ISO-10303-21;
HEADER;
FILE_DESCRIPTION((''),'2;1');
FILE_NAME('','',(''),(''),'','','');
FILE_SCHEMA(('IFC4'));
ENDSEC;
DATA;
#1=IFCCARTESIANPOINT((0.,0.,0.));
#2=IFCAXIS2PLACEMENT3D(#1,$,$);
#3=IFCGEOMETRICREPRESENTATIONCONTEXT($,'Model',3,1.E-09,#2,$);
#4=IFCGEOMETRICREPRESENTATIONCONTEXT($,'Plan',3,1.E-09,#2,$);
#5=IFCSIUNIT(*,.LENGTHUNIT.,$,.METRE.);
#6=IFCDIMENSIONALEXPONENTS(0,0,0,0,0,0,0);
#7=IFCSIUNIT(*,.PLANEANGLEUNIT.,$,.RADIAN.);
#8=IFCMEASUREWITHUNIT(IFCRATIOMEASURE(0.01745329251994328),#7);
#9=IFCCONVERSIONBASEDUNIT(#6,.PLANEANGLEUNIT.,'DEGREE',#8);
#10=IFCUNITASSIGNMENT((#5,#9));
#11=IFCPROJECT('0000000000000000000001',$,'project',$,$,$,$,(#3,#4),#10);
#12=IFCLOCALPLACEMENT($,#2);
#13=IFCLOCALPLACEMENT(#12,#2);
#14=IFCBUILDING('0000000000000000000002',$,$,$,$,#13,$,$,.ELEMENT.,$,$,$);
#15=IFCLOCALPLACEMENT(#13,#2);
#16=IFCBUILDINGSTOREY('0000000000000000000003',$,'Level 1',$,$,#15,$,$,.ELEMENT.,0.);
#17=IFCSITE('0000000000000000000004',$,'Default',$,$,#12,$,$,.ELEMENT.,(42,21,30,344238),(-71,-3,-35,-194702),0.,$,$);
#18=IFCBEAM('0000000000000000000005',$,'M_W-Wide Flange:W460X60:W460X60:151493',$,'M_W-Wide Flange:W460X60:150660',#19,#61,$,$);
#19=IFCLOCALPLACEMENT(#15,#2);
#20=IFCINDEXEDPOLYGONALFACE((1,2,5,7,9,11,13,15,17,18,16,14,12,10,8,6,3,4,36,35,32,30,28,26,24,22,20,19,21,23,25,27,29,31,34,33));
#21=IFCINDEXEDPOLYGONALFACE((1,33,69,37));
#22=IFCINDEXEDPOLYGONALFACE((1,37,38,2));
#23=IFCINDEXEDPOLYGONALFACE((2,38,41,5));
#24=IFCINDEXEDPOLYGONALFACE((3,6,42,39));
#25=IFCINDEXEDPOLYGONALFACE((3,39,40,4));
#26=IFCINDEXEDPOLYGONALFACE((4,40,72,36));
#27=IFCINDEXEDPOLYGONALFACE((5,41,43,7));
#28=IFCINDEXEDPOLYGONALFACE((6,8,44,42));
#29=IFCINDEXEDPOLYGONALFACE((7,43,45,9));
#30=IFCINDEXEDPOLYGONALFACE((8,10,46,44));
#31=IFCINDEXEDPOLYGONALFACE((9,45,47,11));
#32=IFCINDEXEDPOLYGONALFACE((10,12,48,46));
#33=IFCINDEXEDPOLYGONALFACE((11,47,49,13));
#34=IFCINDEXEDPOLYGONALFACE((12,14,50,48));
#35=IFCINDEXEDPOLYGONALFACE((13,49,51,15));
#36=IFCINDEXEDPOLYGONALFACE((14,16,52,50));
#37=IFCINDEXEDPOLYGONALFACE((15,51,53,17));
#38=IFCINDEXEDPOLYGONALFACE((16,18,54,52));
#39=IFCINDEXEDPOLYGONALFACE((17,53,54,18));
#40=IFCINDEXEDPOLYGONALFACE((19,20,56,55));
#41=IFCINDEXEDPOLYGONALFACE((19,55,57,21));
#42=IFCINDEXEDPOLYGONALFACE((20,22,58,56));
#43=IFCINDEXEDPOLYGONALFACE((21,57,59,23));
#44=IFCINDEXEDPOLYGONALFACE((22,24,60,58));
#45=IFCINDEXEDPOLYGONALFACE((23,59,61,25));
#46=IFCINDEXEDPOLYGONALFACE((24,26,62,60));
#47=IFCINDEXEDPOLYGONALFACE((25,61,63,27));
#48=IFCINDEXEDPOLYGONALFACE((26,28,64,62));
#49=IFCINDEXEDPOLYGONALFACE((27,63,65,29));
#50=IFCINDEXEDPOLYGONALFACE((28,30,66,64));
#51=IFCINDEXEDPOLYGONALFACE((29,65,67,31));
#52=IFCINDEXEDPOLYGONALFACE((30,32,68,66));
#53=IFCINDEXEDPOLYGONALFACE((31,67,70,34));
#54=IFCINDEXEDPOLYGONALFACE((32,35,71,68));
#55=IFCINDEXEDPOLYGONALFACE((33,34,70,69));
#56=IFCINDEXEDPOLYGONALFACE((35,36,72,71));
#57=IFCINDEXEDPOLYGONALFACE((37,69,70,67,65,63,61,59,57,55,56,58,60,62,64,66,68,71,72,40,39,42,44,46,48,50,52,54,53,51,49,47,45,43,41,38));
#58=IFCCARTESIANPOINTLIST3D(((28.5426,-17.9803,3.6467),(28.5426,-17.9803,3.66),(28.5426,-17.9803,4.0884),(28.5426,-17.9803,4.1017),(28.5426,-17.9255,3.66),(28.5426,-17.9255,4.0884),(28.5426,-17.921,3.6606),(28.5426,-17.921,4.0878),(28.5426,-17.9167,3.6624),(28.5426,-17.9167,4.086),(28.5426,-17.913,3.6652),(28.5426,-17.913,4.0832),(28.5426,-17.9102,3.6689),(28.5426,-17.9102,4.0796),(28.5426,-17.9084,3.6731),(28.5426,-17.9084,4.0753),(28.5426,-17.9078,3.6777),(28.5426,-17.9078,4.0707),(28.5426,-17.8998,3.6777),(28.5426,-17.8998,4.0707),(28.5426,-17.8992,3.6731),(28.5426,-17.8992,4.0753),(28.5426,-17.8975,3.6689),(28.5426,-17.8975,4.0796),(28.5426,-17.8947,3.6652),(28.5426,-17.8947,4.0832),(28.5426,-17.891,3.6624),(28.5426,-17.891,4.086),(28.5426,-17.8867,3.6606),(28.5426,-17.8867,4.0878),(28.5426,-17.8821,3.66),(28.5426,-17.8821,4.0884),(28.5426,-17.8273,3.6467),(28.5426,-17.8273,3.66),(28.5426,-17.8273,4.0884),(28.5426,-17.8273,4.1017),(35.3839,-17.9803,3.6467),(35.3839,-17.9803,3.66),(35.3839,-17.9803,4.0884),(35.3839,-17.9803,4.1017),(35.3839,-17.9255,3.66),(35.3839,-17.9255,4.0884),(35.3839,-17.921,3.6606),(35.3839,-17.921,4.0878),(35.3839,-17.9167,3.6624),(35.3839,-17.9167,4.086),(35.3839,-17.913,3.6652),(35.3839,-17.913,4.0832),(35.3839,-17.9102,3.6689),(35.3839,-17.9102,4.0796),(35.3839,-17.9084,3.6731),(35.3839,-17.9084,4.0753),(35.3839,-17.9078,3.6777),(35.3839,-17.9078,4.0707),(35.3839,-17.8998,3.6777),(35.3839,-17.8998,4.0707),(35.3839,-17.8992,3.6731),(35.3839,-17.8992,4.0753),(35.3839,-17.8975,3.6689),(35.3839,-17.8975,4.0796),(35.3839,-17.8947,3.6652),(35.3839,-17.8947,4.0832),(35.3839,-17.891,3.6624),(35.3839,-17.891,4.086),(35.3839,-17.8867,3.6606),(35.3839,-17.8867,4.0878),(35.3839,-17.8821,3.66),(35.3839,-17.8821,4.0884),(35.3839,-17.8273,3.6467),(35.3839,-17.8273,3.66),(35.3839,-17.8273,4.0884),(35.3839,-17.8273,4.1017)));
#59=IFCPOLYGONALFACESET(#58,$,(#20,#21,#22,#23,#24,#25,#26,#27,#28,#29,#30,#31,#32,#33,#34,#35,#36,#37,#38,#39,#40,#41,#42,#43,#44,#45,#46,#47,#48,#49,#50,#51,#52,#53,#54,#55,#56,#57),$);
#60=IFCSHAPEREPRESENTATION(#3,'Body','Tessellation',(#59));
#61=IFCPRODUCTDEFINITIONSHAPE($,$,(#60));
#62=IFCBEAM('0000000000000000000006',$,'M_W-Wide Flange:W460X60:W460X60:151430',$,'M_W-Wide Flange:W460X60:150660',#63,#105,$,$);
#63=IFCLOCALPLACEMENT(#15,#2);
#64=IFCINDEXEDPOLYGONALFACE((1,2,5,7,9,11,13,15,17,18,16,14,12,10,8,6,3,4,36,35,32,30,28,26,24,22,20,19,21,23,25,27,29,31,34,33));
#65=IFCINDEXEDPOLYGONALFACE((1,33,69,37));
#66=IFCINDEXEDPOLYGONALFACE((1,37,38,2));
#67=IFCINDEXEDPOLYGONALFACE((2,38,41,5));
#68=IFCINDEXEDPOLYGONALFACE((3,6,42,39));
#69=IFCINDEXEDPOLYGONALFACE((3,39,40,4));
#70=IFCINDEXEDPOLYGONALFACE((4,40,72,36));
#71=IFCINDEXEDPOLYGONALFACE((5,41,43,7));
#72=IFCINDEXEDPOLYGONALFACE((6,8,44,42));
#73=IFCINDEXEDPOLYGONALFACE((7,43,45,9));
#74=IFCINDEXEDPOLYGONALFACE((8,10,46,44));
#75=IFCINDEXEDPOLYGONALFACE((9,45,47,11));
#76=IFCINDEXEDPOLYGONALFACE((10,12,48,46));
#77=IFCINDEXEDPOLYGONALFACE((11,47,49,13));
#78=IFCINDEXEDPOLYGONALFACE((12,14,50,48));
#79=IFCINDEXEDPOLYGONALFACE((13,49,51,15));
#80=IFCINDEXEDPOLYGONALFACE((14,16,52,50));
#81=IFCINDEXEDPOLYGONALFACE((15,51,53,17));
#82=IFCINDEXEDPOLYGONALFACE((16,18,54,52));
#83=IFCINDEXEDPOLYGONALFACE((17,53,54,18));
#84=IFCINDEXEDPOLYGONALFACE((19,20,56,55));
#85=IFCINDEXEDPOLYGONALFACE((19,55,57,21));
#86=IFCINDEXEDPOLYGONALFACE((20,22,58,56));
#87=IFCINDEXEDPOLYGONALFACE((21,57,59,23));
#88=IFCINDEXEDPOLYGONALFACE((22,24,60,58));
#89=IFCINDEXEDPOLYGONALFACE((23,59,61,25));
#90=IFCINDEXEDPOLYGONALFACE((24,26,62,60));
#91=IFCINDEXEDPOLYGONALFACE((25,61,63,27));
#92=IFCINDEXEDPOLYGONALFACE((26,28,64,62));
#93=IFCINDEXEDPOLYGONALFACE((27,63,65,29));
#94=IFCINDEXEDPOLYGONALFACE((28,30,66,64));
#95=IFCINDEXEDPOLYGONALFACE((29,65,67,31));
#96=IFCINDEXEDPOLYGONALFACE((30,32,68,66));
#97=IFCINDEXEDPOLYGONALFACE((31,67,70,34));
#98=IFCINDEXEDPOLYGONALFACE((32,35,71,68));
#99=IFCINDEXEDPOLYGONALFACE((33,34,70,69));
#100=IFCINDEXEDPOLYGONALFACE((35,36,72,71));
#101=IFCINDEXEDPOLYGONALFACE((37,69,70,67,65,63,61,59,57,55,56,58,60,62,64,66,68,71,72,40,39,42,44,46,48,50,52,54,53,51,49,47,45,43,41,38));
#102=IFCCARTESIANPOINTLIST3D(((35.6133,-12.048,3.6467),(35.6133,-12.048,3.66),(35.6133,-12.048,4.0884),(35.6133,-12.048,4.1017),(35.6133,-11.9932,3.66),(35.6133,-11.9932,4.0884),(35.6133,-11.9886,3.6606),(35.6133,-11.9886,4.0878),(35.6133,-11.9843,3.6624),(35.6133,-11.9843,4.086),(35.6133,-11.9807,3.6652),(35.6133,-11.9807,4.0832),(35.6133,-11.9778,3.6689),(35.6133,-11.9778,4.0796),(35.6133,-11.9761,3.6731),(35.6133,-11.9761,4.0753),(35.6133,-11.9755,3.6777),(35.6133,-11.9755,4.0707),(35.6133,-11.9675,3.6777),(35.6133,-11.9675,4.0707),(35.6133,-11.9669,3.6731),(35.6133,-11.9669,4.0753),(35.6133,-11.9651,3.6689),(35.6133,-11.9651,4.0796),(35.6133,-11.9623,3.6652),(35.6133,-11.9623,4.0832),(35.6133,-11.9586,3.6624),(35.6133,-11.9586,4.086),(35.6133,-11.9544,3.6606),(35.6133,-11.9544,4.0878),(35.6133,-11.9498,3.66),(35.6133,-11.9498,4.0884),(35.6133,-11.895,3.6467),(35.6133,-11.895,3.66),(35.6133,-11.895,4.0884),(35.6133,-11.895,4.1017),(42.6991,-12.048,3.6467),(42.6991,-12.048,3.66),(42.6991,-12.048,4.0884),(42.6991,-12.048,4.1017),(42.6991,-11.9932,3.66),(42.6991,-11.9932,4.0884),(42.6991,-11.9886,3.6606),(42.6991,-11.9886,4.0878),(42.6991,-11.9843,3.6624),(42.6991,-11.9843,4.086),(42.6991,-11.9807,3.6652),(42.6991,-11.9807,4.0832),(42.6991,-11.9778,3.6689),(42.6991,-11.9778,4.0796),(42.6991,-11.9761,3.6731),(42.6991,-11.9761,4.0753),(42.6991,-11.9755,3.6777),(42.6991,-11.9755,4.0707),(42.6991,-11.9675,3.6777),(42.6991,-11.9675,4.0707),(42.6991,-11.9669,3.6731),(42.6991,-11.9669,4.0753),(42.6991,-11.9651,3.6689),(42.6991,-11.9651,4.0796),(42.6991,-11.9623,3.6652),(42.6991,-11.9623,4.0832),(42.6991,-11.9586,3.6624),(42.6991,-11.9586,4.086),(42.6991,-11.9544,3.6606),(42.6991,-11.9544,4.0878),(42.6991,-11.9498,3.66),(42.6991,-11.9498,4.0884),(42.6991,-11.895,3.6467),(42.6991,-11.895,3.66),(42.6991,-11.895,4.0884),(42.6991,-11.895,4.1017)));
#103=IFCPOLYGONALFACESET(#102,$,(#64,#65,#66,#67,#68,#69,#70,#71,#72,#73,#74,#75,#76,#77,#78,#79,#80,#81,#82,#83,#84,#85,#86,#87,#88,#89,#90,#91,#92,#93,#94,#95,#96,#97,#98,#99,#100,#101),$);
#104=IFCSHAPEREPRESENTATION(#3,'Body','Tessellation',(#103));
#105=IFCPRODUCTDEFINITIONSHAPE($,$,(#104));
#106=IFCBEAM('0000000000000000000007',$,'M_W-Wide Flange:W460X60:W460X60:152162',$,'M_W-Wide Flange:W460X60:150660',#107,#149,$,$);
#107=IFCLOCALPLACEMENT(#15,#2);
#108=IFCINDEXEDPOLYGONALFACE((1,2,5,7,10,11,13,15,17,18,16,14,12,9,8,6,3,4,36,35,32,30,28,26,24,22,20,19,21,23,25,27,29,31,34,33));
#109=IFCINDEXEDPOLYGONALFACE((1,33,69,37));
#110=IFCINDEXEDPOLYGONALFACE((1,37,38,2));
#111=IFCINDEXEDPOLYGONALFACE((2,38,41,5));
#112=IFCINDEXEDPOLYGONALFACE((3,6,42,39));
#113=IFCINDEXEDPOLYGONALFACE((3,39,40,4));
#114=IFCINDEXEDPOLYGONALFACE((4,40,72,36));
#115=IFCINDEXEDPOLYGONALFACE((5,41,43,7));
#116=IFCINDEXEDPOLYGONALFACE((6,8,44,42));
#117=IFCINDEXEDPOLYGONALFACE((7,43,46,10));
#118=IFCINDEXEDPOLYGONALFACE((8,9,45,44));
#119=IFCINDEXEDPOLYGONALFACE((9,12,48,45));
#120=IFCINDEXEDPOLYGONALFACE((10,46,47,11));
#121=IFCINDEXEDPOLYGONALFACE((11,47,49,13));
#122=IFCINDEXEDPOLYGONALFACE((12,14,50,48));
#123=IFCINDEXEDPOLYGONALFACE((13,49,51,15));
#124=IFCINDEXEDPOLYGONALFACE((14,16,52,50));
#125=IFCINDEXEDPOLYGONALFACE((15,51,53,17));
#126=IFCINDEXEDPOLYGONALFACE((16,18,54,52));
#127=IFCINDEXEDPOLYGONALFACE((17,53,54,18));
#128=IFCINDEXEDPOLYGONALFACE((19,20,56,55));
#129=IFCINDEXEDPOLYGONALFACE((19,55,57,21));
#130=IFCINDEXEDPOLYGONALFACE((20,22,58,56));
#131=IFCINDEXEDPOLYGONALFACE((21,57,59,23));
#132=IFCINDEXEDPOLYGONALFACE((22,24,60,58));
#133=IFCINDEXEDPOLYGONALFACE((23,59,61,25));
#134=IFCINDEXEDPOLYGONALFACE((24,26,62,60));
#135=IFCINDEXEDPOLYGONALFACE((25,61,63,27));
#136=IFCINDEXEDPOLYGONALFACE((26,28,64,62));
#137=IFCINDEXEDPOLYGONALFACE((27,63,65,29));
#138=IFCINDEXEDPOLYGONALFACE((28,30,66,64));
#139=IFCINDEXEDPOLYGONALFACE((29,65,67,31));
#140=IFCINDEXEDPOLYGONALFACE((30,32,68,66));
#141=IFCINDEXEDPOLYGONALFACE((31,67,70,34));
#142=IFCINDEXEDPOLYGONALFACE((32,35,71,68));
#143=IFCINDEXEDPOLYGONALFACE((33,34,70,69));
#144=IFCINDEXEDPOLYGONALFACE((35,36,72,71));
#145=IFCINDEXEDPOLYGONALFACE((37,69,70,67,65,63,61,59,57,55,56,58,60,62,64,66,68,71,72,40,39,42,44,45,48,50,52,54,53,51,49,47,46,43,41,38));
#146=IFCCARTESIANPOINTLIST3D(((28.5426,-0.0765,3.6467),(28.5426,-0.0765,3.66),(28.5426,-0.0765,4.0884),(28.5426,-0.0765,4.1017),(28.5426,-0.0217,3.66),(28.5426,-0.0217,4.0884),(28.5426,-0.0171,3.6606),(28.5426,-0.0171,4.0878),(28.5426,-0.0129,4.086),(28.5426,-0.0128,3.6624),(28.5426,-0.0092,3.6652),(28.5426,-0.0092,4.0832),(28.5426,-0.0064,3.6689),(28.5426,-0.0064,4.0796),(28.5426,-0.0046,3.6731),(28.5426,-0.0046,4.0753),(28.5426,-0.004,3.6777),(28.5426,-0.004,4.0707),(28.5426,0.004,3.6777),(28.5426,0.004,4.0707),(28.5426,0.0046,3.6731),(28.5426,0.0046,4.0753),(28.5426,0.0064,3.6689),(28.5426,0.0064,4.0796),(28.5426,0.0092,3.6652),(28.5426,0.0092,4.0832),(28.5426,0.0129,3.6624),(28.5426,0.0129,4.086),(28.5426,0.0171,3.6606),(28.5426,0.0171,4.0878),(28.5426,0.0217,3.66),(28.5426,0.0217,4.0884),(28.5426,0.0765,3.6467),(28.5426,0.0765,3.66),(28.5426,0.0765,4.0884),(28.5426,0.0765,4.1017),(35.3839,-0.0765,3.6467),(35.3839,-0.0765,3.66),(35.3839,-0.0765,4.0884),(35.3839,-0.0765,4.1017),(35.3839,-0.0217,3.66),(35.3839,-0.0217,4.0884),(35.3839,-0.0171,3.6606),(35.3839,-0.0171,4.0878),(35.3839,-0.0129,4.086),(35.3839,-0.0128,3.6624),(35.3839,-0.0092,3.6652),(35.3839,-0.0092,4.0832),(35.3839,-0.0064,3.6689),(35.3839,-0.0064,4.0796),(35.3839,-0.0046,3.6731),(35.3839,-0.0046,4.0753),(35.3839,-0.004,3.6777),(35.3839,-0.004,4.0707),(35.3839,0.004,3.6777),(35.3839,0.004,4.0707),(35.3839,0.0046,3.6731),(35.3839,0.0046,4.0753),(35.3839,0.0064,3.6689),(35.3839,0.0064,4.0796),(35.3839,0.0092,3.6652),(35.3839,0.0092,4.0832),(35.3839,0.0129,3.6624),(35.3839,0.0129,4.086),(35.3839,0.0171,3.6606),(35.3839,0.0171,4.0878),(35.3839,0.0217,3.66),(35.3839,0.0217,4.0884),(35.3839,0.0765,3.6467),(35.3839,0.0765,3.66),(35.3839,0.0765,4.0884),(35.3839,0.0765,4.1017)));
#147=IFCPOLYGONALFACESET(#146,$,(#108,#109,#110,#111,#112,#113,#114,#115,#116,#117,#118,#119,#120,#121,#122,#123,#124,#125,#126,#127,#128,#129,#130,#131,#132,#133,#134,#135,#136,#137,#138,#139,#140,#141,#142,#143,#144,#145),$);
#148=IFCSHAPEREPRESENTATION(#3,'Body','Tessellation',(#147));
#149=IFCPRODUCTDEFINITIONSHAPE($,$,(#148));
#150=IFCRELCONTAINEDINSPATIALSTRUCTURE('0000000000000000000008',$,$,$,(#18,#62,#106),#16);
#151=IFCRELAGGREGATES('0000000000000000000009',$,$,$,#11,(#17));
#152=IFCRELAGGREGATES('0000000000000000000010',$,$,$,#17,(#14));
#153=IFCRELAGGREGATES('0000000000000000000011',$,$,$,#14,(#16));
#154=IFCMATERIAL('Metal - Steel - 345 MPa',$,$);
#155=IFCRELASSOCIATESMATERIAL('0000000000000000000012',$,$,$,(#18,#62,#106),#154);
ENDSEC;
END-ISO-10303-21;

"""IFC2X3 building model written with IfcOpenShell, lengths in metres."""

from ifc_helpers import new_model, entity, si_unit, converted_unit, frame, frame_2d, origin, place, context, project, spatial, polyline, circle_curve, parameter, trimmed, segment, composite_curve, outline, extrude, material, element, save


model = new_model("IFC2X3")

# Units and contexts
model_context = context("Model", 3, precision=1e-09, world=origin())
plan_context = context("Plan", 3, precision=1e-09, world=origin())
ifc_project = project(units=[si_unit("LENGTHUNIT", "METRE"), converted_unit("PLANEANGLEUNIT", "DEGREE", entity("IfcRatioMeasure", 0.01745329251994328), si_unit("PLANEANGLEUNIT", "RADIAN"), dimensions=[0, 0, 0, 0, 0, 0, 0])], contexts=[model_context, plan_context])

# Site, building, storey
site_placement = place(None, origin())
site = spatial("IfcSite", under=ifc_project, at=site_placement, Name="Default", CompositionType="ELEMENT", RefLatitude=(42, 21, 30, 344238), RefLongitude=(-71, -3, -35, -194702), RefElevation=0.0)
building_placement = place(site_placement, origin())
building = spatial("IfcBuilding", under=site, at=building_placement, CompositionType="ELEMENT")
storey_placement = place(building_placement, origin())
storey = spatial("IfcBuildingStorey", under=building, at=storey_placement, Name="Level 1", CompositionType="ELEMENT", Elevation=0.0)

# Beams
ifc_material = material(Name="Metal - Steel - 345 MPa")
beam_1_placement = place(storey_placement, frame((35.4986, -17.9038, 4.2672), z_axis=(0.0, 0.0, 1.0), x_axis=(0.0, 1.0, 0.0)))
element("IfcBeam", 1, at=beam_1_placement, inside=storey, material=ifc_material, Name="M_W-Wide Flange:W460X60:W460X60:151493", ObjectType="M_W-Wide Flange:W460X60:150660", context=model_context, shape_type="SweptSolid", body=[
    extrude(outline(composite_curve([segment(polyline([(0.2142, -0.0765), (0.2275, -0.0765)]), True, "CONTINUOUS"), segment(polyline([(0.2275, -0.0765), (0.2275, 0.0765)]), True, "CONTINUOUS"), segment(polyline([(0.2275, 0.0765), (0.2142, 0.0765)]), True, "CONTINUOUS"), segment(polyline([(0.2142, 0.0765), (0.2142, 0.0217)]), True, "CONTINUOUS"), segment(trimmed(circle_curve(frame_2d((0.1965, 0.0217), x_axis=(1.0, 0.0)), 0.0177), [parameter(270.0)], [parameter(360.0)], True, "PARAMETER"), False, "CONTINUOUS"), segment(polyline([(0.1965, 0.004), (-0.1965, 0.004)]), True, "CONTINUOUS"), segment(trimmed(circle_curve(frame_2d((-0.1965, 0.0217), x_axis=(0.0, -1.0)), 0.0177), [parameter(270.0)], [parameter(360.0)], True, "PARAMETER"), False, "CONTINUOUS"), segment(polyline([(-0.2142, 0.0217), (-0.2142, 0.0765)]), True, "CONTINUOUS"), segment(polyline([(-0.2142, 0.0765), (-0.2275, 0.0765)]), True, "CONTINUOUS"), segment(polyline([(-0.2275, 0.0765), (-0.2275, -0.0765)]), True, "CONTINUOUS"), segment(polyline([(-0.2275, -0.0765), (-0.2142, -0.0765)]), True, "CONTINUOUS"), segment(polyline([(-0.2142, -0.0765), (-0.2142, -0.0217)]), True, "CONTINUOUS"), segment(trimmed(circle_curve(frame_2d((-0.1965, -0.0217), x_axis=(-1.0, 0.0)), 0.0177), [parameter(270.0)], [parameter(360.0)], True, "PARAMETER"), False, "CONTINUOUS"), segment(polyline([(-0.1965, -0.004), (0.1965, -0.004)]), True, "CONTINUOUS"), segment(trimmed(circle_curve(frame_2d((0.1965, -0.0217), x_axis=(0.0, 1.0)), 0.0177), [parameter(270.0)], [parameter(0.0)], True, "PARAMETER"), False, "CONTINUOUS"), segment(polyline([(0.2142, -0.0217), (0.2142, -0.0765)]), True, "CONTINUOUS")], self_intersect=False)), frame((0.0, 6.9561, -0.393), z_axis=(0.0, -1.0, 0.0), x_axis=(0.0, 0.0, -1.0)), (0.0, 0.0, 1.0), 6.8414),
])
beam_2_placement = place(storey_placement, frame((35.4986, -11.9715, 4.2672), z_axis=(0.0, 0.0, 1.0), x_axis=(0.0, -1.0, 0.0)))
element("IfcBeam", 2, at=beam_2_placement, inside=storey, material=ifc_material, Name="M_W-Wide Flange:W460X60:W460X60:151430", ObjectType="M_W-Wide Flange:W460X60:150660", context=model_context, shape_type="SweptSolid", body=[
    extrude(outline(composite_curve([segment(polyline([(-0.0765, -0.2142), (-0.0765, -0.2275)]), True, "CONTINUOUS"), segment(polyline([(-0.0765, -0.2275), (0.0765, -0.2275)]), True, "CONTINUOUS"), segment(polyline([(0.0765, -0.2275), (0.0765, -0.2142)]), True, "CONTINUOUS"), segment(polyline([(0.0765, -0.2142), (0.0217, -0.2142)]), True, "CONTINUOUS"), segment(trimmed(circle_curve(frame_2d((0.0217, -0.1965), x_axis=(0.0, -1.0)), 0.0177), [parameter(270.0)], [parameter(360.0)], True, "PARAMETER"), False, "CONTINUOUS"), segment(polyline([(0.004, -0.1965), (0.004, 0.1965)]), True, "CONTINUOUS"), segment(trimmed(circle_curve(frame_2d((0.0217, 0.1965), x_axis=(-1.0, 0.0)), 0.0177), [parameter(270.0)], [parameter(360.0)], True, "PARAMETER"), False, "CONTINUOUS"), segment(polyline([(0.0217, 0.2142), (0.0765, 0.2142)]), True, "CONTINUOUS"), segment(polyline([(0.0765, 0.2142), (0.0765, 0.2275)]), True, "CONTINUOUS"), segment(polyline([(0.0765, 0.2275), (-0.0765, 0.2275)]), True, "CONTINUOUS"), segment(polyline([(-0.0765, 0.2275), (-0.0765, 0.2142)]), True, "CONTINUOUS"), segment(polyline([(-0.0765, 0.2142), (-0.0217, 0.2142)]), True, "CONTINUOUS"), segment(trimmed(circle_curve(frame_2d((-0.0217, 0.1965), x_axis=(0.0, 1.0)), 0.0177), [parameter(270.0)], [parameter(360.0)], True, "PARAMETER"), False, "CONTINUOUS"), segment(polyline([(-0.004, 0.1965), (-0.004, -0.1965)]), True, "CONTINUOUS"), segment(trimmed(circle_curve(frame_2d((-0.0217, -0.1965), x_axis=(1.0, 0.0)), 0.0177), [parameter(270.0)], [parameter(0.0)], True, "PARAMETER"), False, "CONTINUOUS"), segment(polyline([(-0.0217, -0.2142), (-0.0765, -0.2142)]), True, "CONTINUOUS")], self_intersect=False)), frame((0.0, 0.1147, -0.393), z_axis=(0.0, -1.0, 0.0), x_axis=(1.0, 0.0, 0.0)), (0.0, 0.0, -1.0), 7.0858),
])
beam_3_placement = place(storey_placement, frame((28.4279, 0.0, 4.2672), z_axis=(0.0, 0.0, 1.0), x_axis=(0.0, -1.0, 0.0)))
element("IfcBeam", 3, at=beam_3_placement, inside=storey, material=ifc_material, Name="M_W-Wide Flange:W460X60:W460X60:152162", ObjectType="M_W-Wide Flange:W460X60:150660", context=model_context, shape_type="SweptSolid", body=[
    extrude(outline(composite_curve([segment(polyline([(-0.0765, -0.2142), (-0.0765, -0.2275)]), True, "CONTINUOUS"), segment(polyline([(-0.0765, -0.2275), (0.0765, -0.2275)]), True, "CONTINUOUS"), segment(polyline([(0.0765, -0.2275), (0.0765, -0.2142)]), True, "CONTINUOUS"), segment(polyline([(0.0765, -0.2142), (0.0217, -0.2142)]), True, "CONTINUOUS"), segment(trimmed(circle_curve(frame_2d((0.0217, -0.1965), x_axis=(0.0, -1.0)), 0.0177), [parameter(270.0)], [parameter(360.0)], True, "PARAMETER"), False, "CONTINUOUS"), segment(polyline([(0.004, -0.1965), (0.004, 0.1965)]), True, "CONTINUOUS"), segment(trimmed(circle_curve(frame_2d((0.0217, 0.1965), x_axis=(-1.0, 0.0)), 0.0177), [parameter(270.0)], [parameter(360.0)], True, "PARAMETER"), False, "CONTINUOUS"), segment(polyline([(0.0217, 0.2142), (0.0765, 0.2142)]), True, "CONTINUOUS"), segment(polyline([(0.0765, 0.2142), (0.0765, 0.2275)]), True, "CONTINUOUS"), segment(polyline([(0.0765, 0.2275), (-0.0765, 0.2275)]), True, "CONTINUOUS"), segment(polyline([(-0.0765, 0.2275), (-0.0765, 0.2142)]), True, "CONTINUOUS"), segment(polyline([(-0.0765, 0.2142), (-0.0217, 0.2142)]), True, "CONTINUOUS"), segment(trimmed(circle_curve(frame_2d((-0.0217, 0.1965), x_axis=(0.0, 1.0)), 0.0177), [parameter(270.0)], [parameter(360.0)], True, "PARAMETER"), False, "CONTINUOUS"), segment(polyline([(-0.004, 0.1965), (-0.004, -0.1965)]), True, "CONTINUOUS"), segment(trimmed(circle_curve(frame_2d((-0.0217, -0.1965), x_axis=(1.0, 0.0)), 0.0177), [parameter(270.0)], [parameter(0.0)], True, "PARAMETER"), False, "CONTINUOUS"), segment(polyline([(-0.0217, -0.2142), (-0.0765, -0.2142)]), True, "CONTINUOUS")], self_intersect=False)), frame((0.0, 0.1147, -0.393), z_axis=(0.0, -1.0, 0.0), x_axis=(1.0, 0.0, 0.0)), (0.0, 0.0, -1.0), 6.8414),
])

save(model, "model.ifc")
